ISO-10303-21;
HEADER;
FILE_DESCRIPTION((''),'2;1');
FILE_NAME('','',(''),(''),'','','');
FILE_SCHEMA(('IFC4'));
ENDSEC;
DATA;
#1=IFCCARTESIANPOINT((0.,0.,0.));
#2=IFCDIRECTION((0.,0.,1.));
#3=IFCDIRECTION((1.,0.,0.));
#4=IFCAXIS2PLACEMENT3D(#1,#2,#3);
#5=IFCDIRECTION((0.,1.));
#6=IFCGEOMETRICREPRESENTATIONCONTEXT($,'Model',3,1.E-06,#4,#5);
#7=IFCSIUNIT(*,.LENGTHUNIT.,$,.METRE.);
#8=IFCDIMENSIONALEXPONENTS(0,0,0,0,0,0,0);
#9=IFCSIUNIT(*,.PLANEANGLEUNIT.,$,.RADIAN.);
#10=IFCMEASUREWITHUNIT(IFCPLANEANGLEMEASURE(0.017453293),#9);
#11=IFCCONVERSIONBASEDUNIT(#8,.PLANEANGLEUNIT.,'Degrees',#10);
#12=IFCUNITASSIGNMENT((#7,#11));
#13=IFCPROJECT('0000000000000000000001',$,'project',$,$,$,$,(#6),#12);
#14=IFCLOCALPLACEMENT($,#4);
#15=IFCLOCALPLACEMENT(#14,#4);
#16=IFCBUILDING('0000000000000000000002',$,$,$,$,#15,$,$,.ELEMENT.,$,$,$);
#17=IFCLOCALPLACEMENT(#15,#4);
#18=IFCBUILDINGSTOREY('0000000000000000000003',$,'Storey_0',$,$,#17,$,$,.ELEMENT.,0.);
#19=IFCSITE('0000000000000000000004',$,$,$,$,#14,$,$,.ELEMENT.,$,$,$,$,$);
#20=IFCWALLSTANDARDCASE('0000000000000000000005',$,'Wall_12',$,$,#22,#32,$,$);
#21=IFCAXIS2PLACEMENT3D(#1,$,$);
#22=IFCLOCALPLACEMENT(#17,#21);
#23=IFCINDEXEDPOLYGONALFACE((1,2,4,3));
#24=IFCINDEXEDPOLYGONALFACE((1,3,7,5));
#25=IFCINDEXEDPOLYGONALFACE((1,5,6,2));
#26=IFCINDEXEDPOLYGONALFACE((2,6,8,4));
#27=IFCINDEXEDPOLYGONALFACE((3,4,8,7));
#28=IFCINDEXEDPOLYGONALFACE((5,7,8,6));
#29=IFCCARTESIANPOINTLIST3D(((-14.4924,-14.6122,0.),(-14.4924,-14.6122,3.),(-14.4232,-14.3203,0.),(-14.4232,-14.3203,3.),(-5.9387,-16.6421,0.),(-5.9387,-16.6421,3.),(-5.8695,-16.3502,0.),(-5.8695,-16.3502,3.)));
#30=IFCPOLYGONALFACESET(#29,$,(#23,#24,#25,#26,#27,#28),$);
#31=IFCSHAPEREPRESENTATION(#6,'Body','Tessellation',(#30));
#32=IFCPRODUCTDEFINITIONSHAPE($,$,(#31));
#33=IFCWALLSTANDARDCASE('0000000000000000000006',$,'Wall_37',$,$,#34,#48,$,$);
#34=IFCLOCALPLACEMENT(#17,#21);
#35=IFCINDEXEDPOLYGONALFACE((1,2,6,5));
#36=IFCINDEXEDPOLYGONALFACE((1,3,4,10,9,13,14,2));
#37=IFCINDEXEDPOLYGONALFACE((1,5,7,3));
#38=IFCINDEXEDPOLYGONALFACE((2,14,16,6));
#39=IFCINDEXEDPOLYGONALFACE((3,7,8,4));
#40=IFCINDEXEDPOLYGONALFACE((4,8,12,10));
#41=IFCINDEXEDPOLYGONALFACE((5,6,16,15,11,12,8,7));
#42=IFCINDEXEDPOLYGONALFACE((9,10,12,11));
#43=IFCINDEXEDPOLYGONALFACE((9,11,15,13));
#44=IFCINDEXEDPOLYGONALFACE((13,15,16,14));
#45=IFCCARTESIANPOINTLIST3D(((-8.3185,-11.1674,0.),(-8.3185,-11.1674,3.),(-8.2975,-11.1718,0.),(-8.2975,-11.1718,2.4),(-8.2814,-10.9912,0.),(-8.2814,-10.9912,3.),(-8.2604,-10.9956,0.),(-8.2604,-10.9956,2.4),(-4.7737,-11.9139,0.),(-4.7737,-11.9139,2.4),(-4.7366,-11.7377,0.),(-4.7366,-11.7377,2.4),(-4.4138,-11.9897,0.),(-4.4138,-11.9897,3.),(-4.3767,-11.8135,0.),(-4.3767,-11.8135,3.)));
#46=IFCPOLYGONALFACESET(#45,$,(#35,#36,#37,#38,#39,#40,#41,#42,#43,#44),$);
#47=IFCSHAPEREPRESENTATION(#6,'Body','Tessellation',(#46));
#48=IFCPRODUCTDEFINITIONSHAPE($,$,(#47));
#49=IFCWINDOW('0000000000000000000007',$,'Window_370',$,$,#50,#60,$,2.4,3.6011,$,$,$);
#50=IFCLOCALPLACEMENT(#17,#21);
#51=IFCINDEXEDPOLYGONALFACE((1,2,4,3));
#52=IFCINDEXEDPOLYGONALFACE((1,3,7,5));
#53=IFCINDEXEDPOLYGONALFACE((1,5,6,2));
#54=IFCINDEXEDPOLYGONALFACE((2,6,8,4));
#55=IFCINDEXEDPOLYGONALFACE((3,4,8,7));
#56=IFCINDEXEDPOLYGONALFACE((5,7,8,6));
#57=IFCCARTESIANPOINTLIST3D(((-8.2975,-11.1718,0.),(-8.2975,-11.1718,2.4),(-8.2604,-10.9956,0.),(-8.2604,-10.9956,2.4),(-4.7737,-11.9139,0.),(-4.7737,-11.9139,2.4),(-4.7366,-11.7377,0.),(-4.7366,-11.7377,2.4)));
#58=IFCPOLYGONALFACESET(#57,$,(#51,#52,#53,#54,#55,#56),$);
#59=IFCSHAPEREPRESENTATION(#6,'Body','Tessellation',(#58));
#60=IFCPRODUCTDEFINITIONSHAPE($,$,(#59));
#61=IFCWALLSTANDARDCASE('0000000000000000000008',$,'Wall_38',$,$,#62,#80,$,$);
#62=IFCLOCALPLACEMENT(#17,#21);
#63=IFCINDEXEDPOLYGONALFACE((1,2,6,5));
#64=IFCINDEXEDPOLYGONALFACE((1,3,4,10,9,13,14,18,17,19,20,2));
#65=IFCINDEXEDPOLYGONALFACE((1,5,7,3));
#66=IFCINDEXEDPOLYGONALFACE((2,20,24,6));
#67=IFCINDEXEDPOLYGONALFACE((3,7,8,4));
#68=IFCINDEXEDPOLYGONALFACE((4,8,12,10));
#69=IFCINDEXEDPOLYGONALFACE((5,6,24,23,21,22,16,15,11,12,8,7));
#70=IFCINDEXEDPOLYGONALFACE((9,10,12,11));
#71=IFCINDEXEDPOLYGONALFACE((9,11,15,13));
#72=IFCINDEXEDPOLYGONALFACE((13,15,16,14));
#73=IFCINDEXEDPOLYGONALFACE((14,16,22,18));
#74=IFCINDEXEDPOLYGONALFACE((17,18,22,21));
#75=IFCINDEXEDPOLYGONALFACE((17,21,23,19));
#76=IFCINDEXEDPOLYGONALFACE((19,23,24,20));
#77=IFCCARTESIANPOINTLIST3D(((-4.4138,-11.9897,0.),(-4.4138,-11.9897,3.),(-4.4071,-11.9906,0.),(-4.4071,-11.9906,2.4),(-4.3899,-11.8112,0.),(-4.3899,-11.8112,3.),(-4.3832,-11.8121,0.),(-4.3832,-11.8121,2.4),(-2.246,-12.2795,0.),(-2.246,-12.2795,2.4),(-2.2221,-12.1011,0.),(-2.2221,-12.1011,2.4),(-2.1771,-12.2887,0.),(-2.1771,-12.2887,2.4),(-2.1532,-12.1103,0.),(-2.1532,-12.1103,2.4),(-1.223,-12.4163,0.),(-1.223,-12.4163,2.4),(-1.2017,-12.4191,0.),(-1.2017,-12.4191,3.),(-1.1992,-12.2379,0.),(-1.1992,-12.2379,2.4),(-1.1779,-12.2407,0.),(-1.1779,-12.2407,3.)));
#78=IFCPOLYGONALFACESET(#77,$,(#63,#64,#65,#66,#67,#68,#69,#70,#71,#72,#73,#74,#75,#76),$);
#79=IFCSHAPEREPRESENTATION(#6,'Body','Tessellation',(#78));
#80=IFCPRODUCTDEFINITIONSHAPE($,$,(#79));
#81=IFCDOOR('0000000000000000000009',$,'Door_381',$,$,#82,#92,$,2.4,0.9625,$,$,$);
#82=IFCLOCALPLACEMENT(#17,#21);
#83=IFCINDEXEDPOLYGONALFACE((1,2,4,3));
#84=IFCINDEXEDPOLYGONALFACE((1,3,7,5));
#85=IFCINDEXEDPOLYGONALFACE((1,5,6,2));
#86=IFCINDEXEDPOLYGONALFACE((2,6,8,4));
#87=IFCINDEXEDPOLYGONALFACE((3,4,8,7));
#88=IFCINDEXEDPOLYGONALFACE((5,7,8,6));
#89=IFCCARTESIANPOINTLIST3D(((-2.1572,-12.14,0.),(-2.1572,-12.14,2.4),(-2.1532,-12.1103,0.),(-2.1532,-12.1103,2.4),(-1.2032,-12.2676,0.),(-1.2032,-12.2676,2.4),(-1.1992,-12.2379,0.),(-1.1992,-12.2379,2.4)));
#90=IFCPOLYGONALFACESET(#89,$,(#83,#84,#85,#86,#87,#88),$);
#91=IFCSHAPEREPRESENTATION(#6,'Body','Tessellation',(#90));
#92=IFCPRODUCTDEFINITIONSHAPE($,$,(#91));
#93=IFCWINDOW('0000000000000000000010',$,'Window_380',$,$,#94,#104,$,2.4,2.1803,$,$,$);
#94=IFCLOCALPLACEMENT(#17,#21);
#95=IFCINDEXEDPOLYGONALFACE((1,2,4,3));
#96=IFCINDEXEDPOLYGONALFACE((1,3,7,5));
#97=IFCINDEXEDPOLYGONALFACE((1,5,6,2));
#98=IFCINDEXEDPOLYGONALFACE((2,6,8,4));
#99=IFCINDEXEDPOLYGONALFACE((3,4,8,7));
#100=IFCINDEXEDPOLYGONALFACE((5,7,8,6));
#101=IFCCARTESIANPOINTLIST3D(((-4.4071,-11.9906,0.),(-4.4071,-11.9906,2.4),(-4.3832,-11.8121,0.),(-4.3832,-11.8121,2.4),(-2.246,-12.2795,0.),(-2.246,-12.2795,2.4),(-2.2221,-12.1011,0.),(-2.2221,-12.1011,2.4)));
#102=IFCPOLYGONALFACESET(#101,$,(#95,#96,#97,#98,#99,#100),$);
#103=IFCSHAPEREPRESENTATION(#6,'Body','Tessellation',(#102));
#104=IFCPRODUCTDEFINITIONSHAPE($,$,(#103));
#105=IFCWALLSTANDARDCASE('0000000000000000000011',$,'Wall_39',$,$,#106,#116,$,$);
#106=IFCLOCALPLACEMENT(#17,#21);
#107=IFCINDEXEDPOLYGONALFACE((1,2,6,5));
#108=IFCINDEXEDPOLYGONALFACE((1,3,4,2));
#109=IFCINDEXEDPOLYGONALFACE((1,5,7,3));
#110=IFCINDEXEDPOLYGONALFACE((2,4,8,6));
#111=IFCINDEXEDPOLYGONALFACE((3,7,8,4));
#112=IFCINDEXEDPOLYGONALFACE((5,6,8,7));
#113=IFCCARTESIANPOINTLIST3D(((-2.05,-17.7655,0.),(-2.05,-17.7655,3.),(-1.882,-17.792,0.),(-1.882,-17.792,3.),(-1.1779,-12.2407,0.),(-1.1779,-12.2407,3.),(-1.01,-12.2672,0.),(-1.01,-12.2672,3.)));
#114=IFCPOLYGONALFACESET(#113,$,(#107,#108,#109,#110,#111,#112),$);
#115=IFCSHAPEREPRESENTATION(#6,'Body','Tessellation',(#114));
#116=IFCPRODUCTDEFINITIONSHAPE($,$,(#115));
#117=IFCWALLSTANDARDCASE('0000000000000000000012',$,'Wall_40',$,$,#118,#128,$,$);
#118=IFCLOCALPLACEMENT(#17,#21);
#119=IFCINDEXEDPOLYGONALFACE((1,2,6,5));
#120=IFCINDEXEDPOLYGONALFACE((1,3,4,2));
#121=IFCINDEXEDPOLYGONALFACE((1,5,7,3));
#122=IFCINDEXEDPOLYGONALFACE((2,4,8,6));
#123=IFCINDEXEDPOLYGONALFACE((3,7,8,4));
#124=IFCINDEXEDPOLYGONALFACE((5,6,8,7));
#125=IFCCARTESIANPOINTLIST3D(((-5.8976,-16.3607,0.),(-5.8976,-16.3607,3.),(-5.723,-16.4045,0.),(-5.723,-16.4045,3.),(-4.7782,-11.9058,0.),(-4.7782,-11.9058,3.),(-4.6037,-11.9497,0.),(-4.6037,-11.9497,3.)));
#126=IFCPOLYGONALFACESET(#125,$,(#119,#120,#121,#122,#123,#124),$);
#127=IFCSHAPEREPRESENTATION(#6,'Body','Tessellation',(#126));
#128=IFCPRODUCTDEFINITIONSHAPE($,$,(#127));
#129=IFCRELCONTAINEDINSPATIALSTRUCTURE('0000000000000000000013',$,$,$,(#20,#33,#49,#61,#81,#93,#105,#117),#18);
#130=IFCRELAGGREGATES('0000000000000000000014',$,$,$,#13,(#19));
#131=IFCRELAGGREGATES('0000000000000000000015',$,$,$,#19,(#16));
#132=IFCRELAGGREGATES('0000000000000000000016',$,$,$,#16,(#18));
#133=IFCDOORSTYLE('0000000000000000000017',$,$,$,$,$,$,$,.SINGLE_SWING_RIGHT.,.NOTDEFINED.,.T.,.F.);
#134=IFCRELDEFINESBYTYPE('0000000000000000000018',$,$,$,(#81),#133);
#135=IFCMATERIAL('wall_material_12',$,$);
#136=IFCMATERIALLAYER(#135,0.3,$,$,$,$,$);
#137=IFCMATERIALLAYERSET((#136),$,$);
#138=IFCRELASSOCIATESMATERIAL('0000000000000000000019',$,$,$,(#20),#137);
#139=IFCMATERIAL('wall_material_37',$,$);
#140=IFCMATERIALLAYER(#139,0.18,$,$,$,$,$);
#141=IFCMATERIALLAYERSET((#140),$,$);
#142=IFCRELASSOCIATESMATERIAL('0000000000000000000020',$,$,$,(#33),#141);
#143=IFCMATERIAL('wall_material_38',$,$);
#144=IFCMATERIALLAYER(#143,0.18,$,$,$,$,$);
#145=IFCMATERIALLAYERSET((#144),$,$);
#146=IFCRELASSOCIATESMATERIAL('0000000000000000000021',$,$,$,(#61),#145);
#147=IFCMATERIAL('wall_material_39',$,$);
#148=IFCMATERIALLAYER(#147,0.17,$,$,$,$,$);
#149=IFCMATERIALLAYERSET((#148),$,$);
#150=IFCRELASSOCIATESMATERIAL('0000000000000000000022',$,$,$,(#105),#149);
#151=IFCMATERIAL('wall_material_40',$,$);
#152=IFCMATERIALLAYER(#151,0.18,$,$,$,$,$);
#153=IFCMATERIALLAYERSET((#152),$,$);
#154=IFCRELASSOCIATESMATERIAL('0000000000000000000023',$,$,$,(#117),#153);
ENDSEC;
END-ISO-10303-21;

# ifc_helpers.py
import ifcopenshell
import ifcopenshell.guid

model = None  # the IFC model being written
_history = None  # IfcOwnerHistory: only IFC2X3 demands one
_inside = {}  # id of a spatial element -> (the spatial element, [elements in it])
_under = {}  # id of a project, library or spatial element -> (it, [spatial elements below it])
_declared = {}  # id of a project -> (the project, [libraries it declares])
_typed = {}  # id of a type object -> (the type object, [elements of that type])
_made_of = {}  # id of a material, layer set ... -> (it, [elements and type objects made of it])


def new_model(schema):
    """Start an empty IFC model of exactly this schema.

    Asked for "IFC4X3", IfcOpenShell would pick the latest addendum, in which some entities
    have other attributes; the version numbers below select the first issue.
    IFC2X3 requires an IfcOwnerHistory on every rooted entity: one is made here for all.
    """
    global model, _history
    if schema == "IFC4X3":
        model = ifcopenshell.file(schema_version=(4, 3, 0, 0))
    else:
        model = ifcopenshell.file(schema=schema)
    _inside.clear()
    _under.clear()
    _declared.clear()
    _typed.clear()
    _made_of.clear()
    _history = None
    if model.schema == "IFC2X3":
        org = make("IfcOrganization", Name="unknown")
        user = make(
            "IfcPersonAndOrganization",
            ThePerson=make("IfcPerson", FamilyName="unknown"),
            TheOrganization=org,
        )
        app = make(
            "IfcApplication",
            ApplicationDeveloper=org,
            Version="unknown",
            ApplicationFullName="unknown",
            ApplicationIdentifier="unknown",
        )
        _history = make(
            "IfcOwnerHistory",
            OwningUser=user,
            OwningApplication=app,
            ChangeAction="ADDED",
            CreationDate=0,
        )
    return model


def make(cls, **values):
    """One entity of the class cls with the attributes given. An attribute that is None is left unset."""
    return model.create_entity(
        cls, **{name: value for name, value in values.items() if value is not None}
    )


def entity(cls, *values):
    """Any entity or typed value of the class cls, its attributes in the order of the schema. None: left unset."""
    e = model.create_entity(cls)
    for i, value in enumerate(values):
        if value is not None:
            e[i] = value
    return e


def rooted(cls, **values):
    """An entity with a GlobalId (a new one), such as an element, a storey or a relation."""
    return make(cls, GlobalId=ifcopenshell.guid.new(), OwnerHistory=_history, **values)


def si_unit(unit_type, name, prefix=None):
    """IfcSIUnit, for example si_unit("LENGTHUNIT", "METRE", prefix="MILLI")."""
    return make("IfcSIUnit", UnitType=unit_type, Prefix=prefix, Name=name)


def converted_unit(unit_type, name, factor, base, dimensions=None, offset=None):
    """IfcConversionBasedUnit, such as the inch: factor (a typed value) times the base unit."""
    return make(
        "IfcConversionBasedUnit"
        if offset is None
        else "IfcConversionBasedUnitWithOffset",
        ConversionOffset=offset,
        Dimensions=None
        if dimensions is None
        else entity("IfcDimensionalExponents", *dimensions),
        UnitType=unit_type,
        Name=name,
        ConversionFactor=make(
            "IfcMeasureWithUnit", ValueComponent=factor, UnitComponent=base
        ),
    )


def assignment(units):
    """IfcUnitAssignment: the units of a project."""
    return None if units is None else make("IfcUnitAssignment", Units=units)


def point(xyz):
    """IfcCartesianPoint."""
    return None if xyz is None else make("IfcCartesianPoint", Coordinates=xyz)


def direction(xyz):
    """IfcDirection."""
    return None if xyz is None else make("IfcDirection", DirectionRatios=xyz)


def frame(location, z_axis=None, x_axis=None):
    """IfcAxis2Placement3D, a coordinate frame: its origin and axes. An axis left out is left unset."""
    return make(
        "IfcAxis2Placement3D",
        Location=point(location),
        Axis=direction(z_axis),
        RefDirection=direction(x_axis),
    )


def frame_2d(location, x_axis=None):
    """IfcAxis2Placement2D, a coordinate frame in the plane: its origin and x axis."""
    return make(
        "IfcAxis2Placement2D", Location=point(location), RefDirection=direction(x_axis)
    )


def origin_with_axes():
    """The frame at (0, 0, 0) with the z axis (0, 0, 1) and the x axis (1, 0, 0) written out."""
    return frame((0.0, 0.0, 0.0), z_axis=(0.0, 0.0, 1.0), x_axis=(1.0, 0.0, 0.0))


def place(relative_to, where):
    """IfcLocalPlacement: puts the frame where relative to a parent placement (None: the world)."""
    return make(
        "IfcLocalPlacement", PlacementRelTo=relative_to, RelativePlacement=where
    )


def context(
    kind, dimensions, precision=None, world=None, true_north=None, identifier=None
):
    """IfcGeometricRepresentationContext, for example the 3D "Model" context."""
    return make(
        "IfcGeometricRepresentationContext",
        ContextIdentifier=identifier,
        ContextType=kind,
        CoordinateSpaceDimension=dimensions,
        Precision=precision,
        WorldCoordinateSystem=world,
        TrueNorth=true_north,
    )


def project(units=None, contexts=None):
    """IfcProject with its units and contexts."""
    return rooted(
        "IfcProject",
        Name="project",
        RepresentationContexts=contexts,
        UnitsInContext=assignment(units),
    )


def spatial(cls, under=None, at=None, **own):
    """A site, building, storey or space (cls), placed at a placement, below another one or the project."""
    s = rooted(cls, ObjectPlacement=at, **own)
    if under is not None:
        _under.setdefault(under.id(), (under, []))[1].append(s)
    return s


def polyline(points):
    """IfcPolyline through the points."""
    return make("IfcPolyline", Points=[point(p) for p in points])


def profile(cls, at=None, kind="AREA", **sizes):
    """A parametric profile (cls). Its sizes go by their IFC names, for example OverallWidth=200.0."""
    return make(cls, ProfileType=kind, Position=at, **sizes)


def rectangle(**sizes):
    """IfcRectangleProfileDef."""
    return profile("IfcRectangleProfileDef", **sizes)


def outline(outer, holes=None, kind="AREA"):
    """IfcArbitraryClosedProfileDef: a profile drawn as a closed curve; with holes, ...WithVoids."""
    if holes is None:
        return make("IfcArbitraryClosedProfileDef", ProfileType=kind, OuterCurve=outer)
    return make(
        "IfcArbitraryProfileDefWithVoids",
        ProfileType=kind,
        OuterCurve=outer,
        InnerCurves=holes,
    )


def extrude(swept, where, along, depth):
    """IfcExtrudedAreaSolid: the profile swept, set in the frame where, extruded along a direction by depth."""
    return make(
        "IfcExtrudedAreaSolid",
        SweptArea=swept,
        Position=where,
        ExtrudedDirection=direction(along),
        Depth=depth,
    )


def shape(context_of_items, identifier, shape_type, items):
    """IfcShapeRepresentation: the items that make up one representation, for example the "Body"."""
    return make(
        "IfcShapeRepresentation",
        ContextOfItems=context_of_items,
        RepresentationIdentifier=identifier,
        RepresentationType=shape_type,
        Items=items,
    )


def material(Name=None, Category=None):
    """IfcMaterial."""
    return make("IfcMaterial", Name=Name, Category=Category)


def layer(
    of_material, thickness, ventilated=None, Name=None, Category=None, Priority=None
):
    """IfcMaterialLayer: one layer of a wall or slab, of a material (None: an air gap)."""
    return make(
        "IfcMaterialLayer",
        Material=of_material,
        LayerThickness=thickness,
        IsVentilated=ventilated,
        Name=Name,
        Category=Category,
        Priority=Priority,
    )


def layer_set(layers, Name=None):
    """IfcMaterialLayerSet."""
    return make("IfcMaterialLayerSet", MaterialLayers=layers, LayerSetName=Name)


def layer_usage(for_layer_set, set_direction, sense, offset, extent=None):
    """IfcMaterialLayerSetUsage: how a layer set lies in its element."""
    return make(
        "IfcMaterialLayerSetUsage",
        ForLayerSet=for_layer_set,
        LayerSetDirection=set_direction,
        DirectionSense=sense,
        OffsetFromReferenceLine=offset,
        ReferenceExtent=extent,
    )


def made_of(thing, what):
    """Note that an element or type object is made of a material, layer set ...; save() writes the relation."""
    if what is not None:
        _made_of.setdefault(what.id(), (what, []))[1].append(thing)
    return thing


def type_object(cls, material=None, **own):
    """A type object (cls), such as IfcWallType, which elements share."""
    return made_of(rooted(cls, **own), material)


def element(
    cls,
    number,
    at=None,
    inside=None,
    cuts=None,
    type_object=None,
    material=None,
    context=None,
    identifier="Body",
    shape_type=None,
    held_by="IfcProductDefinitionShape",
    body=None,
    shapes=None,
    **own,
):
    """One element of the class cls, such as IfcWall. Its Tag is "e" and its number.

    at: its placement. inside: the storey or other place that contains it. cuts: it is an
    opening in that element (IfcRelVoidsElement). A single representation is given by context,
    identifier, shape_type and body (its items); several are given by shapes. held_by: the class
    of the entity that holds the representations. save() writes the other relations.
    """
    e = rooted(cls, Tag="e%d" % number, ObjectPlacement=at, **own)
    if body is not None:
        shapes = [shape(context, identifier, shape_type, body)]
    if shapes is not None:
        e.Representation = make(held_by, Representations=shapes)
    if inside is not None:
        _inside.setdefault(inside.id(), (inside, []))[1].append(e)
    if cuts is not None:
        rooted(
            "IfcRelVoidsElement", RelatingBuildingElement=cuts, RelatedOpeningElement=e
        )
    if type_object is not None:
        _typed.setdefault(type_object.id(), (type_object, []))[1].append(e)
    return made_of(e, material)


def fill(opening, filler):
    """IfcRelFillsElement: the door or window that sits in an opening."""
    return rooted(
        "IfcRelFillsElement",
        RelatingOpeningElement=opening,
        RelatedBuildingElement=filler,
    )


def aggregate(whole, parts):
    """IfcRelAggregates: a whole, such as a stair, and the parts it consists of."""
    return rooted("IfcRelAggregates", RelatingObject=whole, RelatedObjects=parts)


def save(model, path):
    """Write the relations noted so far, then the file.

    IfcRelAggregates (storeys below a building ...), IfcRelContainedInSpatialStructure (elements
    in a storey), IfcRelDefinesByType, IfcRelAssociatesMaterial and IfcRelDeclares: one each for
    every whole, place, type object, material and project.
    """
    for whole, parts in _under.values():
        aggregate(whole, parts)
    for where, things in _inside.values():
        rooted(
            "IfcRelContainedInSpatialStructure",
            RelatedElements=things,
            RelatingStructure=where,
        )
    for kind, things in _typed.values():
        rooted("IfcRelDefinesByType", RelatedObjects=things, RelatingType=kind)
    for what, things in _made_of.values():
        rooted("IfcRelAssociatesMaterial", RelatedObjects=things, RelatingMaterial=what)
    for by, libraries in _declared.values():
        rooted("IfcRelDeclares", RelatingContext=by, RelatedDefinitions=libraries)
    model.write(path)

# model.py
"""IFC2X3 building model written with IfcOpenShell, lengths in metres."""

from ifc_helpers import new_model, entity, si_unit, converted_unit, direction, frame, frame_2d, origin_with_axes, place, context, project, spatial, polyline, rectangle, outline, extrude, material, layer, layer_set, layer_usage, type_object, element, fill, save


model = new_model("IFC2X3")

# Units and contexts
model_context = context("Model", 3, precision=1e-06, world=origin_with_axes(), true_north=direction((0.0, 1.0)))
ifc_project = project(units=[si_unit("LENGTHUNIT", "METRE"), converted_unit("PLANEANGLEUNIT", "Degrees", entity("IfcPlaneAngleMeasure", 0.017453293), si_unit("PLANEANGLEUNIT", "RADIAN"), dimensions=[0, 0, 0, 0, 0, 0, 0])], contexts=[model_context])

# Site, building, storey
site_placement = place(None, origin_with_axes())
site = spatial("IfcSite", under=ifc_project, at=site_placement, CompositionType="ELEMENT")
building_placement = place(site_placement, origin_with_axes())
building = spatial("IfcBuilding", under=site, at=building_placement, CompositionType="ELEMENT")
storey_placement = place(building_placement, origin_with_axes())
storey = spatial("IfcBuildingStorey", under=building, at=storey_placement, Name="Storey_0", CompositionType="ELEMENT", Elevation=0.0)

# Wall
ifc_material_1 = material(Name="wall_material_12")
ifc_layer_1 = layer(ifc_material_1, 0.3)
ifc_layer_set_1 = layer_set([ifc_layer_1])
ifc_layer_usage_1 = layer_usage(ifc_layer_set_1, "AXIS2", "NEGATIVE", 0.0)
wall_1_placement = place(storey_placement, frame((-5.9387, -16.6421, 0.0), z_axis=(0.0, 0.0, 1.0), x_axis=(-0.972978, 0.230899, 0.0)))
element("IfcWallStandardCase", 1, at=wall_1_placement, inside=storey, material=ifc_layer_usage_1, Name="Wall_12", context=model_context, shape_type="SweptSolid", body=[
    extrude(outline(polyline([(0.0, 0.0), (8.7913, 0.0), (8.7913, -0.3), (0.0, -0.3), (0.0, 0.0)])), origin_with_axes(), (0.0, 0.0, 1.0), 3.0),
])

# Wall, opening, window
ifc_material_2 = material(Name="wall_material_37")
ifc_layer_2 = layer(ifc_material_2, 0.18)
ifc_layer_set_2 = layer_set([ifc_layer_2])
ifc_layer_usage_2 = layer_usage(ifc_layer_set_2, "AXIS2", "NEGATIVE", 0.0)
wall_2_placement = place(storey_placement, frame((-8.2814, -10.9912, 0.0), z_axis=(0.0, 0.0, 1.0), x_axis=(0.978537, -0.206071, 0.0)))
wall_2 = element("IfcWallStandardCase", 2, at=wall_2_placement, inside=storey, material=ifc_layer_usage_2, Name="Wall_37", context=model_context, shape_type="SweptSolid", body=[
    extrude(outline(polyline([(0.0, 0.0), (3.9904, 0.0), (3.9904, -0.18), (0.0, -0.18), (0.0, 0.0)])), origin_with_axes(), (0.0, 0.0, 1.0), 3.0),
])
opening_1_placement = place(wall_2_placement, frame((0.0214, 0.0, 0.0), z_axis=(0.0, 0.0, 1.0), x_axis=(1.0, 0.0, 0.0)))
opening_1 = element("IfcOpeningElement", 3, at=opening_1_placement, cuts=wall_2, context=model_context, shape_type="SweptSolid", body=[
    extrude(rectangle(XDim=3.6011, YDim=2.4, at=frame_2d((1.2, -1.8006), x_axis=(0.0, 1.0))), frame((0.0, 0.01, 0.0), z_axis=(0.0, -1.0, 0.0), x_axis=(0.0, 0.0, 1.0)), (0.0, 0.0, 1.0), 0.2),
])
window_1_placement = place(storey_placement, origin_with_axes())
window_1 = element("IfcWindow", 4, at=window_1_placement, inside=storey, Name="Window_370", OverallHeight=2.4, OverallWidth=3.6011, context=model_context, shape_type="SweptSolid", body=[
    extrude(outline(polyline([(-8.2604, -10.9956), (-4.7366, -11.7377), (-4.7737, -11.9139), (-8.2975, -11.1718), (-8.2604, -10.9956)])), origin_with_axes(), (0.0, 0.0, 1.0), 2.4),
])
fill(opening_1, window_1)

# Wall, openings, door, window
ifc_material_3 = material(Name="wall_material_38")
ifc_layer_3 = layer(ifc_material_3, 0.18)
ifc_layer_set_3 = layer_set([ifc_layer_3])
ifc_layer_usage_3 = layer_usage(ifc_layer_set_3, "AXIS2", "NEGATIVE", 0.0)
wall_3_placement = place(storey_placement, frame((-4.3899, -11.8112, 0.0), z_axis=(0.0, 0.0, 1.0), x_axis=(0.991179, -0.132528, 0.0)))
wall_3 = element("IfcWallStandardCase", 5, at=wall_3_placement, inside=storey, material=ifc_layer_usage_3, Name="Wall_38", context=model_context, shape_type="SweptSolid", body=[
    extrude(outline(polyline([(0.0, 0.0), (3.2406, 0.0), (3.2406, -0.18), (0.0, -0.18), (0.0, 0.0)])), origin_with_axes(), (0.0, 0.0, 1.0), 3.0),
])
opening_2_placement = place(wall_3_placement, frame((0.0067, 0.0, 0.0), z_axis=(0.0, 0.0, 1.0), x_axis=(1.0, 0.0, 0.0)))
opening_2 = element("IfcOpeningElement", 6, at=opening_2_placement, cuts=wall_3, context=model_context, shape_type="SweptSolid", body=[
    extrude(rectangle(XDim=2.1803, YDim=2.4, at=frame_2d((1.2, -1.0902), x_axis=(0.0, 1.0))), frame((0.0, 0.01, 0.0), z_axis=(0.0, -1.0, 0.0), x_axis=(0.0, 0.0, 1.0)), (0.0, 0.0, 1.0), 0.2),
])
opening_3_placement = place(wall_3_placement, frame((2.2566, 0.0, 0.0), z_axis=(0.0, 0.0, 1.0), x_axis=(1.0, 0.0, 0.0)))
opening_3 = element("IfcOpeningElement", 7, at=opening_3_placement, cuts=wall_3, context=model_context, shape_type="SweptSolid", body=[
    extrude(rectangle(XDim=0.9625, YDim=2.4, at=frame_2d((1.2, -0.4813), x_axis=(0.0, 1.0))), frame((0.0, 0.01, 0.0), z_axis=(0.0, -1.0, 0.0), x_axis=(0.0, 0.0, 1.0)), (0.0, 0.0, 1.0), 0.2),
])
door_style_1 = type_object("IfcDoorStyle", ConstructionType="NOTDEFINED", OperationType="SINGLE_SWING_RIGHT", ParameterTakesPrecedence=True, Sizeable=False)
door_1_placement = place(storey_placement, origin_with_axes())
door_1 = element("IfcDoor", 8, at=door_1_placement, inside=storey, type_object=door_style_1, Name="Door_381", OverallHeight=2.4, OverallWidth=0.9625, context=model_context, shape_type="SweptSolid", body=[
    extrude(outline(polyline([(-2.1532, -12.1103), (-1.1992, -12.2379), (-1.2032, -12.2676), (-2.1572, -12.14), (-2.1532, -12.1103)])), origin_with_axes(), (0.0, 0.0, 1.0), 2.4),
])
fill(opening_3, door_1)
window_2_placement = place(storey_placement, origin_with_axes())
window_2 = element("IfcWindow", 9, at=window_2_placement, inside=storey, Name="Window_380", OverallHeight=2.4, OverallWidth=2.1803, context=model_context, shape_type="SweptSolid", body=[
    extrude(outline(polyline([(-4.3832, -11.8121), (-2.2221, -12.1011), (-2.246, -12.2795), (-4.4071, -11.9906), (-4.3832, -11.8121)])), origin_with_axes(), (0.0, 0.0, 1.0), 2.4),
])
fill(opening_2, window_2)

# Walls
ifc_material_4 = material(Name="wall_material_39")
ifc_layer_4 = layer(ifc_material_4, 0.17)
ifc_layer_set_4 = layer_set([ifc_layer_4])
ifc_layer_usage_4 = layer_usage(ifc_layer_set_4, "AXIS2", "NEGATIVE", 0.0)
wall_4_placement = place(storey_placement, frame((-1.01, -12.2672, 0.0), z_axis=(0.0, 0.0, 1.0), x_axis=(-0.155917, -0.98777, 0.0)))
element("IfcWallStandardCase", 10, at=wall_4_placement, inside=storey, material=ifc_layer_usage_4, Name="Wall_39", context=model_context, shape_type="SweptSolid", body=[
    extrude(outline(polyline([(0.0, 0.0), (5.5932, 0.0), (5.5932, -0.17), (0.0, -0.17), (0.0, 0.0)])), origin_with_axes(), (0.0, 0.0, 1.0), 3.0),
])
ifc_material_5 = material(Name="wall_material_40")
ifc_layer_5 = layer(ifc_material_5, 0.18)
ifc_layer_set_5 = layer_set([ifc_layer_5])
ifc_layer_usage_5 = layer_usage(ifc_layer_set_5, "AXIS2", "POSITIVE", 0.0)
wall_5_placement = place(storey_placement, frame((-4.7782, -11.9058, 0.0), z_axis=(0.0, 0.0, 1.0), x_axis=(-0.243686, -0.969854, 0.0)))
element("IfcWallStandardCase", 11, at=wall_5_placement, inside=storey, material=ifc_layer_usage_5, Name="Wall_40", context=model_context, shape_type="SweptSolid", body=[
    extrude(outline(polyline([(0.0, 0.18), (4.5934, 0.18), (4.5934, 0.0), (0.0, 0.0), (0.0, 0.18)])), origin_with_axes(), (0.0, 0.0, 1.0), 3.0),
])

save(model, "model.ifc")
